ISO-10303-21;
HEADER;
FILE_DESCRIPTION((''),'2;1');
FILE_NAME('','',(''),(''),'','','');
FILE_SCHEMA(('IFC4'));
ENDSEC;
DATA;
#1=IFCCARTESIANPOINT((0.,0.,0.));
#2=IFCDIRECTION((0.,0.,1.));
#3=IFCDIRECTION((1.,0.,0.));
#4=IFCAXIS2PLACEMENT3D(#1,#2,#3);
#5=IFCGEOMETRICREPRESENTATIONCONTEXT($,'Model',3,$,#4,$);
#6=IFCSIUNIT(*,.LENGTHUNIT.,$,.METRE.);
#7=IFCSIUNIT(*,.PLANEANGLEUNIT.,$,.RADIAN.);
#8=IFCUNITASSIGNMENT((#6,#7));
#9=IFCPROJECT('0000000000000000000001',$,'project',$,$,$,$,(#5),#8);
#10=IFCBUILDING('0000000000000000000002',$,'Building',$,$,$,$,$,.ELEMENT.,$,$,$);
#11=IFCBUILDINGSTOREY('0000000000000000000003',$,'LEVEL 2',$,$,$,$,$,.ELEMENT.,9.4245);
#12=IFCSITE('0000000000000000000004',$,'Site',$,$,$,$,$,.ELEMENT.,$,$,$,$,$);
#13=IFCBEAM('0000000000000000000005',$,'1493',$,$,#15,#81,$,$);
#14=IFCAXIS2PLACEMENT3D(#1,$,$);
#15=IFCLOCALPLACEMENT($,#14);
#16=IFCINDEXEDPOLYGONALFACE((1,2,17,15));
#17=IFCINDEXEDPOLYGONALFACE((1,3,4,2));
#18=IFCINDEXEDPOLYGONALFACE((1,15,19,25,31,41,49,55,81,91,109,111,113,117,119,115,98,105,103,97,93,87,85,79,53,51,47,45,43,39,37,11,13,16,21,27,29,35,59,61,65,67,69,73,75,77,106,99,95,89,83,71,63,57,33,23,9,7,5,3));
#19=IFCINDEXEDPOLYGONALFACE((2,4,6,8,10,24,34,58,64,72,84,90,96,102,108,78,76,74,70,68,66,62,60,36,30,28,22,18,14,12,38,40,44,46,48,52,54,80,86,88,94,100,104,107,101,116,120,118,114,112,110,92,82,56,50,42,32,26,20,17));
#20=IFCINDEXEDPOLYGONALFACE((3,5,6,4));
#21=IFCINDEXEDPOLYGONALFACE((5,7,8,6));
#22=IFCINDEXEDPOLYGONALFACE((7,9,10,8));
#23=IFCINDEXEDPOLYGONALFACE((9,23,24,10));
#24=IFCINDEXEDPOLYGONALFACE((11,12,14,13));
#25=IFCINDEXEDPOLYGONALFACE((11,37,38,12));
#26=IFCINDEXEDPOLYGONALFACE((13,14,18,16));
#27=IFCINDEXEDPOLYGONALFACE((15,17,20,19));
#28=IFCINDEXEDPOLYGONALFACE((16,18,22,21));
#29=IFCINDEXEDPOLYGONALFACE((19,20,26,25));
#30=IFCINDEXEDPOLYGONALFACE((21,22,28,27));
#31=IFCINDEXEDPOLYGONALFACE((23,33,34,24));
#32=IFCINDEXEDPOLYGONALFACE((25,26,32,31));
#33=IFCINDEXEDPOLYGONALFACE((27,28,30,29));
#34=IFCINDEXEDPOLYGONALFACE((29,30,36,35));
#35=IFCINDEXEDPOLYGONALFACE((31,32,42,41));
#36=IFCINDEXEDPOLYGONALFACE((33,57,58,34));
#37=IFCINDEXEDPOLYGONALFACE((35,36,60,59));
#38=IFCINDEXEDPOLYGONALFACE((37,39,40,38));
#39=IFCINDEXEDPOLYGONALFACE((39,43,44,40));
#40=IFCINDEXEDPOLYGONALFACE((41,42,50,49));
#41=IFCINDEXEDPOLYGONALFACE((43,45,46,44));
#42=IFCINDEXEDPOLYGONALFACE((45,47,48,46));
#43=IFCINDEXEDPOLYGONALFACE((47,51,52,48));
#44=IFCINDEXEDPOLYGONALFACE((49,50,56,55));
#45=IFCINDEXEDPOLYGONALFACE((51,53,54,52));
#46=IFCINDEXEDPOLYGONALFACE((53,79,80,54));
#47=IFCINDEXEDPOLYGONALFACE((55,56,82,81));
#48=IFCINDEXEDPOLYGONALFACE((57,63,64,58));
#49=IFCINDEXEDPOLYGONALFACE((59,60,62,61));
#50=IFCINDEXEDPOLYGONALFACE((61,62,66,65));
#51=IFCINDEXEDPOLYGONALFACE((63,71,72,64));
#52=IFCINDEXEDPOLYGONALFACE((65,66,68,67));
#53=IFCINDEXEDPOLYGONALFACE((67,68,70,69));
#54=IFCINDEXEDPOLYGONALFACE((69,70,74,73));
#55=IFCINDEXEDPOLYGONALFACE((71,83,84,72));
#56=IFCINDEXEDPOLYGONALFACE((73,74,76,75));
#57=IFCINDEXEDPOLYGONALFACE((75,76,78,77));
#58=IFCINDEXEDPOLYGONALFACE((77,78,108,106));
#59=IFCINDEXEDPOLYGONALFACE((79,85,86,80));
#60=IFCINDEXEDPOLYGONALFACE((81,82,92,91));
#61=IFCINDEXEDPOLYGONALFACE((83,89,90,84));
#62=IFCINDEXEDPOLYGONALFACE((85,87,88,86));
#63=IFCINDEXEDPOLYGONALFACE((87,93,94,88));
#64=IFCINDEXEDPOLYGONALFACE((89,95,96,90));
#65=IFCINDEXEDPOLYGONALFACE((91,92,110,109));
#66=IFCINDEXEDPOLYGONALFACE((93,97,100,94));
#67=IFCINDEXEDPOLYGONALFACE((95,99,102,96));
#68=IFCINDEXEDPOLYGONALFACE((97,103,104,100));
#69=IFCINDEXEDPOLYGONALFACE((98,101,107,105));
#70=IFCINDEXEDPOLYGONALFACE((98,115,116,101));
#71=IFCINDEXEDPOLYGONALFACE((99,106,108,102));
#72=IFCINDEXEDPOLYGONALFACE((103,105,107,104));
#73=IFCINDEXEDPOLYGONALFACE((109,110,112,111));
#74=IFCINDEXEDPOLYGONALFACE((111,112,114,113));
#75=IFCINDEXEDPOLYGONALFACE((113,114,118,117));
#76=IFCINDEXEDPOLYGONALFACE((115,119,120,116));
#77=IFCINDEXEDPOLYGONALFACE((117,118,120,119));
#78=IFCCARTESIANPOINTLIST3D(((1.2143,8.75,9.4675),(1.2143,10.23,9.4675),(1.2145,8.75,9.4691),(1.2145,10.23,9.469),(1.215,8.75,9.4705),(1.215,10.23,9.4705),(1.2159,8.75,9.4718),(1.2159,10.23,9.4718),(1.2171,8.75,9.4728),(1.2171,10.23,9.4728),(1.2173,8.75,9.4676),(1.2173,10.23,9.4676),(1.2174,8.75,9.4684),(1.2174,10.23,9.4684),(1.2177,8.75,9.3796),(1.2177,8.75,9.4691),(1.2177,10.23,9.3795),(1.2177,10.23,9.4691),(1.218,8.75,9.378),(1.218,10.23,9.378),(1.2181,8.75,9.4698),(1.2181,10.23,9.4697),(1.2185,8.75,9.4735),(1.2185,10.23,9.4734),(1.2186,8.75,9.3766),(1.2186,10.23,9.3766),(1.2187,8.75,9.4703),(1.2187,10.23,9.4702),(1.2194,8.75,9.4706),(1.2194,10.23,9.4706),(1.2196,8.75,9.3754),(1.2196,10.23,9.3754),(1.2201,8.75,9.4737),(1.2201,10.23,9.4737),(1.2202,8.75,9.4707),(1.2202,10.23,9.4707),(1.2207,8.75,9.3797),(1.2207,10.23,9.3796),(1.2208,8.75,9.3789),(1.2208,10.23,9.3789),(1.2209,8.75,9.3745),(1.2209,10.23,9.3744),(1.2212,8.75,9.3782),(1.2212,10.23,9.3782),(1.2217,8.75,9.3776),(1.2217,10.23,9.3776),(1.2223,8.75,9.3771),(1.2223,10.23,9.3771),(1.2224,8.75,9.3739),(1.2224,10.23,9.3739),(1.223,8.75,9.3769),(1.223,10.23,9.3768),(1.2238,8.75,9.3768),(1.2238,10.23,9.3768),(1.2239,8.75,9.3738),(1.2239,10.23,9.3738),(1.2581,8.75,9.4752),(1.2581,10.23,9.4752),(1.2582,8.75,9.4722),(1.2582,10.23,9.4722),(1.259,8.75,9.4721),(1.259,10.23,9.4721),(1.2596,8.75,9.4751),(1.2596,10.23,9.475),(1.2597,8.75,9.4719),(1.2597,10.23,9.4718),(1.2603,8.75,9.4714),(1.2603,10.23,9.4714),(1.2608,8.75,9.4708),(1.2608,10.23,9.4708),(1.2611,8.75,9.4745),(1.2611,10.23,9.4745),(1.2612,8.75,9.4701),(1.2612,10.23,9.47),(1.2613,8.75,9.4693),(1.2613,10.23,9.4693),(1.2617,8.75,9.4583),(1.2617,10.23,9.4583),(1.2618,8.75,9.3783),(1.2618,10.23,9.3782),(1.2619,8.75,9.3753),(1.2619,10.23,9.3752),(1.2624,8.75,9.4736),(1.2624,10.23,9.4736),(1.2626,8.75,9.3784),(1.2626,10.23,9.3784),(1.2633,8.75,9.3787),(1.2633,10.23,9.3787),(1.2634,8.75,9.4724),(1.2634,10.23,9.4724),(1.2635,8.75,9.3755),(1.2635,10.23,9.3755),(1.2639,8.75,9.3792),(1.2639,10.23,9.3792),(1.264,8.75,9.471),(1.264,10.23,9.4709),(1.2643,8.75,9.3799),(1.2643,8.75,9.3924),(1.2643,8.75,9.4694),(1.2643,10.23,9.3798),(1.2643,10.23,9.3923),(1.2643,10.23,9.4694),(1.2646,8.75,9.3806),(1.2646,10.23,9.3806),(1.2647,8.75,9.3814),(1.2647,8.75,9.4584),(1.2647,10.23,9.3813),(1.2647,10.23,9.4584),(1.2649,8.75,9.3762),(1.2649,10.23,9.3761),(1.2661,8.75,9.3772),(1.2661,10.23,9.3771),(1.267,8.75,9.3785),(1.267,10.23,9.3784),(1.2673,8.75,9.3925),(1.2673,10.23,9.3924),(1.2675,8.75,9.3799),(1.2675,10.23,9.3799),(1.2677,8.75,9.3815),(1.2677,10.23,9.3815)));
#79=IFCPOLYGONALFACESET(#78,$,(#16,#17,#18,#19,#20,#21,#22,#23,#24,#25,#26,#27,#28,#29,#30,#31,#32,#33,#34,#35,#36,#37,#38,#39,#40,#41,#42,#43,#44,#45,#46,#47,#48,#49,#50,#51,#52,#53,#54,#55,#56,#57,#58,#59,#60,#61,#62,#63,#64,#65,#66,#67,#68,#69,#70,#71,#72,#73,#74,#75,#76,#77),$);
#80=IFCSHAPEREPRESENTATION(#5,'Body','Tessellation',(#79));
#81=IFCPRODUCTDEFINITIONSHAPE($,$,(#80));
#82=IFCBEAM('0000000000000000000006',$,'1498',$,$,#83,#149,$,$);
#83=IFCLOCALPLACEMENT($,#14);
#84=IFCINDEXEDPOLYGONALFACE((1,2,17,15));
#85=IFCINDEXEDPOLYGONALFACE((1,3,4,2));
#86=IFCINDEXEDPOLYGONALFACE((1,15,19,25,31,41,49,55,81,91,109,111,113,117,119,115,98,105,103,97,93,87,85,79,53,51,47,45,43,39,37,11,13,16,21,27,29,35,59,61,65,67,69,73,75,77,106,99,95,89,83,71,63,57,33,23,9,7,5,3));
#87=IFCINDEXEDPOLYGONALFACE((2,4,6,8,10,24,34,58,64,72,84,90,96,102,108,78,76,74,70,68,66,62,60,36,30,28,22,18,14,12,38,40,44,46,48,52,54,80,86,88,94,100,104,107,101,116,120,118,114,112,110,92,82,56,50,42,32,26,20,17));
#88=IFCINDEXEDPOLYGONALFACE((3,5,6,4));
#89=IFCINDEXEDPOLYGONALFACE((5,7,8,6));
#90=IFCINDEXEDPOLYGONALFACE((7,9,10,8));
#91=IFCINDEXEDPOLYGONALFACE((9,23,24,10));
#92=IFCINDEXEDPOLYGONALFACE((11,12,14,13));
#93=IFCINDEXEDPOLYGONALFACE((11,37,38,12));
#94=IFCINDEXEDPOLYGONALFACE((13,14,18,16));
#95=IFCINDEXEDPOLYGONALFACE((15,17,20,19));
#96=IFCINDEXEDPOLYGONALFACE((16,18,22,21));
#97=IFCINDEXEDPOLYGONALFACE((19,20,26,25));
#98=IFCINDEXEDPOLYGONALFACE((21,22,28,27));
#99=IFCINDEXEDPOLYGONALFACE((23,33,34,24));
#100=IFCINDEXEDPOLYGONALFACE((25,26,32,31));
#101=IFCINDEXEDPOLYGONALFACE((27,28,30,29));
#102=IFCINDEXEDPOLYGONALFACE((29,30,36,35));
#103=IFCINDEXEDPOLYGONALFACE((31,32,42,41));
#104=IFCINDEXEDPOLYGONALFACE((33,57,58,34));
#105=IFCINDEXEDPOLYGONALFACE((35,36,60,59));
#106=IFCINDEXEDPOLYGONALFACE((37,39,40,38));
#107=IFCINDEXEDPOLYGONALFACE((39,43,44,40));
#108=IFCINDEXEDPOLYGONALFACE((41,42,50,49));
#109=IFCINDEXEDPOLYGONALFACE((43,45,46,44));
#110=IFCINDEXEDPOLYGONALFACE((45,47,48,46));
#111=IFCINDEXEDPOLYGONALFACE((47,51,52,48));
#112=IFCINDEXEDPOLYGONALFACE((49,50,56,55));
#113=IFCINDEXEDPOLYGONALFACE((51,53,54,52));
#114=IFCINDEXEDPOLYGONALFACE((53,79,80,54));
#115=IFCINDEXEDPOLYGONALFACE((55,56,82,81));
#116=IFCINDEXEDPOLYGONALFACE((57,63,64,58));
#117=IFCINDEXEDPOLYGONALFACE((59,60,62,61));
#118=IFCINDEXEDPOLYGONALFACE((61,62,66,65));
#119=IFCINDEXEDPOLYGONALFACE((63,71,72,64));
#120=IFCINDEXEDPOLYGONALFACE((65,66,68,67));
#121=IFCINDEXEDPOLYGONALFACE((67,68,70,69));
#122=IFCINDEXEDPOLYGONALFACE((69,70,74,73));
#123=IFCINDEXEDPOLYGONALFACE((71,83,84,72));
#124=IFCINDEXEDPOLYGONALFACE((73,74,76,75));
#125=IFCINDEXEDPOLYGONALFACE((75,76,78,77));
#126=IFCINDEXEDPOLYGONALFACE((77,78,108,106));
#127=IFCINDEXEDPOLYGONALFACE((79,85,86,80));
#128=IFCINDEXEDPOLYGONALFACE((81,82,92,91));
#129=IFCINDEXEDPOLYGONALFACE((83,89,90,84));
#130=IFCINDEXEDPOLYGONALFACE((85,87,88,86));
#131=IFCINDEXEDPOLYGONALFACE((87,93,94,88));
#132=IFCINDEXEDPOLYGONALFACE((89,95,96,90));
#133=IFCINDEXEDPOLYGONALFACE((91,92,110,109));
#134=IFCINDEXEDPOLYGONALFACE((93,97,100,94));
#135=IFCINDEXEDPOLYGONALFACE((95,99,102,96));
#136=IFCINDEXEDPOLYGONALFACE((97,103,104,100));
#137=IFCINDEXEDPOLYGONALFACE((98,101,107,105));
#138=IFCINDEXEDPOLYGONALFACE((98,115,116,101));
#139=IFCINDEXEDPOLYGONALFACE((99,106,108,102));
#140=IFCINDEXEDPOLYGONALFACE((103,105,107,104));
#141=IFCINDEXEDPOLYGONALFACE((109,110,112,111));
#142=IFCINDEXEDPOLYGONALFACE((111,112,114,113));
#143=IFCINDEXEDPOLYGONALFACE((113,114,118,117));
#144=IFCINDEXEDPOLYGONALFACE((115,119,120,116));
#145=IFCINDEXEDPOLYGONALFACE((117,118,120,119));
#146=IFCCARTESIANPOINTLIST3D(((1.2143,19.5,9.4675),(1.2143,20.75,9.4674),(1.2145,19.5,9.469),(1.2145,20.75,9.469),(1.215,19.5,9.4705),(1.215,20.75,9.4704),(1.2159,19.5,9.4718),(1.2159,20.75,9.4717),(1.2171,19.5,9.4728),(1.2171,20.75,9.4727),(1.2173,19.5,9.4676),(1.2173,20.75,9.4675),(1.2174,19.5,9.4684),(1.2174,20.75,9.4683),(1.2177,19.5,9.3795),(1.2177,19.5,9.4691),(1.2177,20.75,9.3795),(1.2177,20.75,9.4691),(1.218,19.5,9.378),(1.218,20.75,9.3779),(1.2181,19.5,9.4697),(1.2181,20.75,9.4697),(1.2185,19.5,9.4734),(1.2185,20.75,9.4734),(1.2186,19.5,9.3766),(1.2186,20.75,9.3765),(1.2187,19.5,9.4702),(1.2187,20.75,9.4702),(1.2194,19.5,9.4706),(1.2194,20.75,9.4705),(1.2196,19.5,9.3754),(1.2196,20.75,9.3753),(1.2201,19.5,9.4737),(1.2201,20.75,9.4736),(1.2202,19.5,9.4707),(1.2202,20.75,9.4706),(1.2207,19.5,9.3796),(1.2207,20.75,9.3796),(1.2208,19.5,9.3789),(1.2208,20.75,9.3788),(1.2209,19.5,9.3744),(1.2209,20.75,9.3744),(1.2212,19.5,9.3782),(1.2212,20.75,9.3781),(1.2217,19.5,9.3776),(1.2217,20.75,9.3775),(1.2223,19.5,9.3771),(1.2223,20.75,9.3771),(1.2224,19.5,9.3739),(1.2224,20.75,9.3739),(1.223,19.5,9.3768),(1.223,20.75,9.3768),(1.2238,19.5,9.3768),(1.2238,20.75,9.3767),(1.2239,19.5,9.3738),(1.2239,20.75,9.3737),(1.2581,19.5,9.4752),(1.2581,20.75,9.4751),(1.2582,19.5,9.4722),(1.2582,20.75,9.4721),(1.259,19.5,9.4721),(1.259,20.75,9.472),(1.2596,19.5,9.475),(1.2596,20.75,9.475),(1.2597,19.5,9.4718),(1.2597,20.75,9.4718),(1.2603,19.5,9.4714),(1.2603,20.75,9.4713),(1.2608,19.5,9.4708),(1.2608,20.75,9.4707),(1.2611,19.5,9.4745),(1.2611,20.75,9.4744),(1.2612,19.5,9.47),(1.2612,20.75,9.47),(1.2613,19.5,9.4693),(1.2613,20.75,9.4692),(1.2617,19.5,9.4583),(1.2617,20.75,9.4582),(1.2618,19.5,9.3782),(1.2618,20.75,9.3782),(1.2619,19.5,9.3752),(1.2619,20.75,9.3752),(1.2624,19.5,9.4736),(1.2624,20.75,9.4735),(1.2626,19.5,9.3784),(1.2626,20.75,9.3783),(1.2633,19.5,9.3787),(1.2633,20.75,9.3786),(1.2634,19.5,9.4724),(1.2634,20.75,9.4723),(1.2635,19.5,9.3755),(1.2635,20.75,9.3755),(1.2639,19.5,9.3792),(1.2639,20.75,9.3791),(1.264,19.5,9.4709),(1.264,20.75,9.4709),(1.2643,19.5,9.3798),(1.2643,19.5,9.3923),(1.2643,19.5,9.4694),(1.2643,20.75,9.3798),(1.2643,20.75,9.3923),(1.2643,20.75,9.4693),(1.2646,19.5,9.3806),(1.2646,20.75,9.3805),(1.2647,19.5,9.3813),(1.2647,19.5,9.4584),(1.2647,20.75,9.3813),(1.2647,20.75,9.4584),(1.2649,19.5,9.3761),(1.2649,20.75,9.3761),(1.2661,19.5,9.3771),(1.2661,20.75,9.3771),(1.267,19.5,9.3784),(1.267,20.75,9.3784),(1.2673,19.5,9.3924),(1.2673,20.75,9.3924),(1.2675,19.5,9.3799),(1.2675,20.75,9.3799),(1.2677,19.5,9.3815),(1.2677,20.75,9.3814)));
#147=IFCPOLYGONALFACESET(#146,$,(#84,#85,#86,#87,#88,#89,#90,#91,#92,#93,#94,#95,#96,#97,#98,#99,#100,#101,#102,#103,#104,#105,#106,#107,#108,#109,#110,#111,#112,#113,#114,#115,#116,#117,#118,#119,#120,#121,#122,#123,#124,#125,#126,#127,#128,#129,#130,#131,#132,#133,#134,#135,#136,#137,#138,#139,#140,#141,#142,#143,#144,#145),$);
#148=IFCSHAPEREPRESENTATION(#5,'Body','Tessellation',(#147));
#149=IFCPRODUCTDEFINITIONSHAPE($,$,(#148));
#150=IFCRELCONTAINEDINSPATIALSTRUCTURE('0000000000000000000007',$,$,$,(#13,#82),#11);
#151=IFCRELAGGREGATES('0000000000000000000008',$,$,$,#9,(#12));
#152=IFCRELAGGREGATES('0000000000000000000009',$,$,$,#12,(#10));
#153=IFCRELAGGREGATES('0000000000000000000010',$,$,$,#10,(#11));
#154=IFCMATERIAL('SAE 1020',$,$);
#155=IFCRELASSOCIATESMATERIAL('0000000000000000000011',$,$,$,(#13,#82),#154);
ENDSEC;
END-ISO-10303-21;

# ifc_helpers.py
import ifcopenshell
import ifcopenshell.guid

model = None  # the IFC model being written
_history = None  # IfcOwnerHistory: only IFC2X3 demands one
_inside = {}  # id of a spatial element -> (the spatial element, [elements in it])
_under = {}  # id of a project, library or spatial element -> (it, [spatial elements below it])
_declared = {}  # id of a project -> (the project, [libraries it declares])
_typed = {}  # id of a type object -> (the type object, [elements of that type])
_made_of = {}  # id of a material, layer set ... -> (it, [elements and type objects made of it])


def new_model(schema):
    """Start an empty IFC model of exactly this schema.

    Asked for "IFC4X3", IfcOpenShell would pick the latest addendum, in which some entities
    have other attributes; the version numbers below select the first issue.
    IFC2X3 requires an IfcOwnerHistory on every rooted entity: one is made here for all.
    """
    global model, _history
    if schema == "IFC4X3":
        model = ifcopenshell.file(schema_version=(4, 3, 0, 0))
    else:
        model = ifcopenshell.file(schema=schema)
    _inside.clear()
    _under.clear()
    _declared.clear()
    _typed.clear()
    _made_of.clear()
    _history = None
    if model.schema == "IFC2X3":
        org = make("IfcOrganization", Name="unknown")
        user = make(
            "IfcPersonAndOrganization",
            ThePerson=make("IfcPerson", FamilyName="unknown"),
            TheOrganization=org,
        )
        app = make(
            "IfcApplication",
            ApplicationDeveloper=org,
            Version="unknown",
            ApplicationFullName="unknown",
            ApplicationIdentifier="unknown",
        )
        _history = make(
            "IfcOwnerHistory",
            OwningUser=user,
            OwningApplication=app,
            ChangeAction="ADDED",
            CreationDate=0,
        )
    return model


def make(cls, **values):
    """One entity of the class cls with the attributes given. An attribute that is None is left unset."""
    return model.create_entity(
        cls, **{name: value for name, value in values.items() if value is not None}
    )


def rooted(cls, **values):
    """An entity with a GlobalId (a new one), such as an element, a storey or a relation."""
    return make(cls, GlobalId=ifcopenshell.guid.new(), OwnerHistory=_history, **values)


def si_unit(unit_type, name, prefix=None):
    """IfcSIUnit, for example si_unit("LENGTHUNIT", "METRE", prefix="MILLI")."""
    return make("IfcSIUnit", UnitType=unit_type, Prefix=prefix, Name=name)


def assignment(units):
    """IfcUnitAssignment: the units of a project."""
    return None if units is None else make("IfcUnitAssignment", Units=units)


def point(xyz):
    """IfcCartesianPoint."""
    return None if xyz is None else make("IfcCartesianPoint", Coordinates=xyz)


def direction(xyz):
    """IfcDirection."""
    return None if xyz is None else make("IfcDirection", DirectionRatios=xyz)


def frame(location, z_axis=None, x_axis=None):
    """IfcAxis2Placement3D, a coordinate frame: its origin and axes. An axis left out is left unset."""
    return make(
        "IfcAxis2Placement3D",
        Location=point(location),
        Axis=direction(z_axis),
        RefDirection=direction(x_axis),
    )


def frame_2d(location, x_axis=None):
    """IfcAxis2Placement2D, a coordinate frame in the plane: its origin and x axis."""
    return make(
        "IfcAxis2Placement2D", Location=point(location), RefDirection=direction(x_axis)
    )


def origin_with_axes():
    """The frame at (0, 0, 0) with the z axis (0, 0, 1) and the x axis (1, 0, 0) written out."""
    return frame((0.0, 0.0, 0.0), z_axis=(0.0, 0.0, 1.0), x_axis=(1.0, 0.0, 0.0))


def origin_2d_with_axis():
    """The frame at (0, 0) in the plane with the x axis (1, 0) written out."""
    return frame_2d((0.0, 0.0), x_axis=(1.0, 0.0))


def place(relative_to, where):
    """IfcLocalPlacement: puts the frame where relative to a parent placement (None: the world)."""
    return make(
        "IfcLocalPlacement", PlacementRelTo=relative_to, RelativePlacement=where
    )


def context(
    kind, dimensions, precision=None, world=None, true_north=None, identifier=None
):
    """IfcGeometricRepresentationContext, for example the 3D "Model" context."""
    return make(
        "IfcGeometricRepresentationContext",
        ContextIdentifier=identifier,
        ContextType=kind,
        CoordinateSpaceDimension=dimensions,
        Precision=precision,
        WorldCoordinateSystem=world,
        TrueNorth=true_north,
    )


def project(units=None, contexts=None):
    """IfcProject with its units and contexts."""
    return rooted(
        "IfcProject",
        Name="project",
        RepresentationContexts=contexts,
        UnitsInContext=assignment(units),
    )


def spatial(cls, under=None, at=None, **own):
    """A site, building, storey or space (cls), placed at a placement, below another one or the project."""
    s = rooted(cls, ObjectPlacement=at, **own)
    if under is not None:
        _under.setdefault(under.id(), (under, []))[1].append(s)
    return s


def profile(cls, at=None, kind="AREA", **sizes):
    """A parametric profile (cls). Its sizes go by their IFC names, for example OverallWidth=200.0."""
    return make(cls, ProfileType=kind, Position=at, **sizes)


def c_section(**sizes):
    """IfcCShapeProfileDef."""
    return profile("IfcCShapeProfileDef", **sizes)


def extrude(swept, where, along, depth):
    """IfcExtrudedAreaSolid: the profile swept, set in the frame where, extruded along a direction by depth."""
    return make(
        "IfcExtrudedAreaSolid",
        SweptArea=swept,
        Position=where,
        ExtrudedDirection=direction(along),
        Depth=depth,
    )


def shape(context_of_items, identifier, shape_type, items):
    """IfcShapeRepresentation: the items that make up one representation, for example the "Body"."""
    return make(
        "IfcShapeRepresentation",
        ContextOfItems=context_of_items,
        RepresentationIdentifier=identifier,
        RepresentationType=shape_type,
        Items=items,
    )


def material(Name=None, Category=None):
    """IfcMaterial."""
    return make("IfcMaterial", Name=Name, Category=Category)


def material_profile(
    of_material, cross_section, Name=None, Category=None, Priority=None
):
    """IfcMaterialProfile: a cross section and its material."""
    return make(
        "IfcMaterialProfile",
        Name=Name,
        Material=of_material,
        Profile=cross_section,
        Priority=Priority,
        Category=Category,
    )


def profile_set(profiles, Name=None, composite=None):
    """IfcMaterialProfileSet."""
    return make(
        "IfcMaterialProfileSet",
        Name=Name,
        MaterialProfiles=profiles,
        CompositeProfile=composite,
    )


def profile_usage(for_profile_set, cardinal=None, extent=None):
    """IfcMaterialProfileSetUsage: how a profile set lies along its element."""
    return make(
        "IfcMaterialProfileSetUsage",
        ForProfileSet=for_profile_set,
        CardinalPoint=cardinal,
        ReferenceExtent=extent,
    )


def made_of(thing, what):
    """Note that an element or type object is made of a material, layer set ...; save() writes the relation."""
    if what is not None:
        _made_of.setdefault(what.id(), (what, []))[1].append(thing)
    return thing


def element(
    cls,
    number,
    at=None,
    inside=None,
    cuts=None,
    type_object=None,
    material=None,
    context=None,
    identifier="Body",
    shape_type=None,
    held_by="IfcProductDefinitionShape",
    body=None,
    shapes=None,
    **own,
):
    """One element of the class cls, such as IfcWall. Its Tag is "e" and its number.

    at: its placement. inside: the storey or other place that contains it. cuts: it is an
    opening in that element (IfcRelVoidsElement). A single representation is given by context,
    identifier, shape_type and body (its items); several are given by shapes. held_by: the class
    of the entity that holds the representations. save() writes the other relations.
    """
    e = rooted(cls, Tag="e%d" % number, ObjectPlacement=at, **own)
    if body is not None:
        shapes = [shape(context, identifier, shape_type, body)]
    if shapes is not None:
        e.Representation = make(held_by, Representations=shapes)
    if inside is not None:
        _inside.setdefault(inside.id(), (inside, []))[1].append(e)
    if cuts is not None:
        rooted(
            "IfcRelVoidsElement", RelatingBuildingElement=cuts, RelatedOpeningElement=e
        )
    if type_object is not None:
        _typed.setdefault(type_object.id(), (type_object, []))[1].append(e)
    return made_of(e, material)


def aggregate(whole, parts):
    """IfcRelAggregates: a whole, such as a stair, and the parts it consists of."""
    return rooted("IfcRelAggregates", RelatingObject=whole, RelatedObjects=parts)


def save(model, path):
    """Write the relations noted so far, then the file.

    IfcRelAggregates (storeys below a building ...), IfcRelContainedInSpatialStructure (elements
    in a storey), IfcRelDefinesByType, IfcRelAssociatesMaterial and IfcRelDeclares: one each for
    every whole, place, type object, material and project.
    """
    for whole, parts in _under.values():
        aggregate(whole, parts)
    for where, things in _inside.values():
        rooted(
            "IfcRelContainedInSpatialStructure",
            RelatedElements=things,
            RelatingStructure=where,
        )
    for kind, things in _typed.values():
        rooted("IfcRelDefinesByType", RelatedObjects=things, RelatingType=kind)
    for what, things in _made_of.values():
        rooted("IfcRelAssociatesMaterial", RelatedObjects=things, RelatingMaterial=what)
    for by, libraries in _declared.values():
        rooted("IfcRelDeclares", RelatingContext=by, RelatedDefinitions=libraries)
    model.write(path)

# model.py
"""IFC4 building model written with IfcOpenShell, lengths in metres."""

from ifc_helpers import new_model, si_unit, frame, origin_with_axes, origin_2d_with_axis, place, context, project, spatial, c_section, extrude, material, material_profile, profile_set, profile_usage, element, save


model = new_model("IFC4")

# Units and contexts
model_context = context("Model", 3, world=origin_with_axes())
ifc_project = project(units=[si_unit("LENGTHUNIT", "METRE"), si_unit("PLANEANGLEUNIT", "RADIAN")], contexts=[model_context])

# Site, building, storey
site = spatial("IfcSite", under=ifc_project, Name="Site", CompositionType="ELEMENT")
building = spatial("IfcBuilding", under=site, Name="Building", CompositionType="ELEMENT")
storey = spatial("IfcBuildingStorey", under=building, Name="LEVEL 2", CompositionType="ELEMENT", Elevation=9.4245)

# Beams
ifc_material = material(Name="SAE 1020")
ifc_material_profile_1 = material_profile(ifc_material, c_section(Depth=0.1, Width=0.05, WallThickness=0.003, Girth=0.017, InternalFilletRadius=0.003, at=origin_2d_with_axis()))
ifc_profile_set_1 = profile_set([ifc_material_profile_1])
ifc_profile_usage_1 = profile_usage(ifc_profile_set_1, cardinal=10)
beam_1_placement = place(None, frame((1.241, 8.75, 9.4245), z_axis=(0.0, 1.0, -0.00003), x_axis=(0.999256, 0.000001, 0.038562)))
element("IfcBeam", 1, at=beam_1_placement, inside=storey, material=ifc_profile_usage_1, Name="1493", context=model_context, shape_type="SweptSolid", body=[
    extrude(c_section(Depth=0.1, Width=0.05, WallThickness=0.003, Girth=0.017, InternalFilletRadius=0.003, at=origin_2d_with_axis()), origin_with_axes(), (0.0, 0.0, 1.0), 1.48),
])
ifc_material_profile_2 = material_profile(ifc_material, c_section(Depth=0.1, Width=0.05, WallThickness=0.003, Girth=0.017, InternalFilletRadius=0.003, at=origin_2d_with_axis()))
ifc_profile_set_2 = profile_set([ifc_material_profile_2])
ifc_profile_usage_2 = profile_usage(ifc_profile_set_2, cardinal=10)
beam_2_placement = place(None, frame((1.241, 19.5, 9.4245), z_axis=(0.0, 1.0, -0.00003), x_axis=(0.999256, 0.000001, 0.038562)))
element("IfcBeam", 2, at=beam_2_placement, inside=storey, material=ifc_profile_usage_2, Name="1498", context=model_context, shape_type="SweptSolid", body=[
    extrude(c_section(Depth=0.1, Width=0.05, WallThickness=0.003, Girth=0.017, InternalFilletRadius=0.003, at=origin_2d_with_axis()), origin_with_axes(), (0.0, 0.0, 1.0), 1.25),
])

save(model, "model.ifc")
